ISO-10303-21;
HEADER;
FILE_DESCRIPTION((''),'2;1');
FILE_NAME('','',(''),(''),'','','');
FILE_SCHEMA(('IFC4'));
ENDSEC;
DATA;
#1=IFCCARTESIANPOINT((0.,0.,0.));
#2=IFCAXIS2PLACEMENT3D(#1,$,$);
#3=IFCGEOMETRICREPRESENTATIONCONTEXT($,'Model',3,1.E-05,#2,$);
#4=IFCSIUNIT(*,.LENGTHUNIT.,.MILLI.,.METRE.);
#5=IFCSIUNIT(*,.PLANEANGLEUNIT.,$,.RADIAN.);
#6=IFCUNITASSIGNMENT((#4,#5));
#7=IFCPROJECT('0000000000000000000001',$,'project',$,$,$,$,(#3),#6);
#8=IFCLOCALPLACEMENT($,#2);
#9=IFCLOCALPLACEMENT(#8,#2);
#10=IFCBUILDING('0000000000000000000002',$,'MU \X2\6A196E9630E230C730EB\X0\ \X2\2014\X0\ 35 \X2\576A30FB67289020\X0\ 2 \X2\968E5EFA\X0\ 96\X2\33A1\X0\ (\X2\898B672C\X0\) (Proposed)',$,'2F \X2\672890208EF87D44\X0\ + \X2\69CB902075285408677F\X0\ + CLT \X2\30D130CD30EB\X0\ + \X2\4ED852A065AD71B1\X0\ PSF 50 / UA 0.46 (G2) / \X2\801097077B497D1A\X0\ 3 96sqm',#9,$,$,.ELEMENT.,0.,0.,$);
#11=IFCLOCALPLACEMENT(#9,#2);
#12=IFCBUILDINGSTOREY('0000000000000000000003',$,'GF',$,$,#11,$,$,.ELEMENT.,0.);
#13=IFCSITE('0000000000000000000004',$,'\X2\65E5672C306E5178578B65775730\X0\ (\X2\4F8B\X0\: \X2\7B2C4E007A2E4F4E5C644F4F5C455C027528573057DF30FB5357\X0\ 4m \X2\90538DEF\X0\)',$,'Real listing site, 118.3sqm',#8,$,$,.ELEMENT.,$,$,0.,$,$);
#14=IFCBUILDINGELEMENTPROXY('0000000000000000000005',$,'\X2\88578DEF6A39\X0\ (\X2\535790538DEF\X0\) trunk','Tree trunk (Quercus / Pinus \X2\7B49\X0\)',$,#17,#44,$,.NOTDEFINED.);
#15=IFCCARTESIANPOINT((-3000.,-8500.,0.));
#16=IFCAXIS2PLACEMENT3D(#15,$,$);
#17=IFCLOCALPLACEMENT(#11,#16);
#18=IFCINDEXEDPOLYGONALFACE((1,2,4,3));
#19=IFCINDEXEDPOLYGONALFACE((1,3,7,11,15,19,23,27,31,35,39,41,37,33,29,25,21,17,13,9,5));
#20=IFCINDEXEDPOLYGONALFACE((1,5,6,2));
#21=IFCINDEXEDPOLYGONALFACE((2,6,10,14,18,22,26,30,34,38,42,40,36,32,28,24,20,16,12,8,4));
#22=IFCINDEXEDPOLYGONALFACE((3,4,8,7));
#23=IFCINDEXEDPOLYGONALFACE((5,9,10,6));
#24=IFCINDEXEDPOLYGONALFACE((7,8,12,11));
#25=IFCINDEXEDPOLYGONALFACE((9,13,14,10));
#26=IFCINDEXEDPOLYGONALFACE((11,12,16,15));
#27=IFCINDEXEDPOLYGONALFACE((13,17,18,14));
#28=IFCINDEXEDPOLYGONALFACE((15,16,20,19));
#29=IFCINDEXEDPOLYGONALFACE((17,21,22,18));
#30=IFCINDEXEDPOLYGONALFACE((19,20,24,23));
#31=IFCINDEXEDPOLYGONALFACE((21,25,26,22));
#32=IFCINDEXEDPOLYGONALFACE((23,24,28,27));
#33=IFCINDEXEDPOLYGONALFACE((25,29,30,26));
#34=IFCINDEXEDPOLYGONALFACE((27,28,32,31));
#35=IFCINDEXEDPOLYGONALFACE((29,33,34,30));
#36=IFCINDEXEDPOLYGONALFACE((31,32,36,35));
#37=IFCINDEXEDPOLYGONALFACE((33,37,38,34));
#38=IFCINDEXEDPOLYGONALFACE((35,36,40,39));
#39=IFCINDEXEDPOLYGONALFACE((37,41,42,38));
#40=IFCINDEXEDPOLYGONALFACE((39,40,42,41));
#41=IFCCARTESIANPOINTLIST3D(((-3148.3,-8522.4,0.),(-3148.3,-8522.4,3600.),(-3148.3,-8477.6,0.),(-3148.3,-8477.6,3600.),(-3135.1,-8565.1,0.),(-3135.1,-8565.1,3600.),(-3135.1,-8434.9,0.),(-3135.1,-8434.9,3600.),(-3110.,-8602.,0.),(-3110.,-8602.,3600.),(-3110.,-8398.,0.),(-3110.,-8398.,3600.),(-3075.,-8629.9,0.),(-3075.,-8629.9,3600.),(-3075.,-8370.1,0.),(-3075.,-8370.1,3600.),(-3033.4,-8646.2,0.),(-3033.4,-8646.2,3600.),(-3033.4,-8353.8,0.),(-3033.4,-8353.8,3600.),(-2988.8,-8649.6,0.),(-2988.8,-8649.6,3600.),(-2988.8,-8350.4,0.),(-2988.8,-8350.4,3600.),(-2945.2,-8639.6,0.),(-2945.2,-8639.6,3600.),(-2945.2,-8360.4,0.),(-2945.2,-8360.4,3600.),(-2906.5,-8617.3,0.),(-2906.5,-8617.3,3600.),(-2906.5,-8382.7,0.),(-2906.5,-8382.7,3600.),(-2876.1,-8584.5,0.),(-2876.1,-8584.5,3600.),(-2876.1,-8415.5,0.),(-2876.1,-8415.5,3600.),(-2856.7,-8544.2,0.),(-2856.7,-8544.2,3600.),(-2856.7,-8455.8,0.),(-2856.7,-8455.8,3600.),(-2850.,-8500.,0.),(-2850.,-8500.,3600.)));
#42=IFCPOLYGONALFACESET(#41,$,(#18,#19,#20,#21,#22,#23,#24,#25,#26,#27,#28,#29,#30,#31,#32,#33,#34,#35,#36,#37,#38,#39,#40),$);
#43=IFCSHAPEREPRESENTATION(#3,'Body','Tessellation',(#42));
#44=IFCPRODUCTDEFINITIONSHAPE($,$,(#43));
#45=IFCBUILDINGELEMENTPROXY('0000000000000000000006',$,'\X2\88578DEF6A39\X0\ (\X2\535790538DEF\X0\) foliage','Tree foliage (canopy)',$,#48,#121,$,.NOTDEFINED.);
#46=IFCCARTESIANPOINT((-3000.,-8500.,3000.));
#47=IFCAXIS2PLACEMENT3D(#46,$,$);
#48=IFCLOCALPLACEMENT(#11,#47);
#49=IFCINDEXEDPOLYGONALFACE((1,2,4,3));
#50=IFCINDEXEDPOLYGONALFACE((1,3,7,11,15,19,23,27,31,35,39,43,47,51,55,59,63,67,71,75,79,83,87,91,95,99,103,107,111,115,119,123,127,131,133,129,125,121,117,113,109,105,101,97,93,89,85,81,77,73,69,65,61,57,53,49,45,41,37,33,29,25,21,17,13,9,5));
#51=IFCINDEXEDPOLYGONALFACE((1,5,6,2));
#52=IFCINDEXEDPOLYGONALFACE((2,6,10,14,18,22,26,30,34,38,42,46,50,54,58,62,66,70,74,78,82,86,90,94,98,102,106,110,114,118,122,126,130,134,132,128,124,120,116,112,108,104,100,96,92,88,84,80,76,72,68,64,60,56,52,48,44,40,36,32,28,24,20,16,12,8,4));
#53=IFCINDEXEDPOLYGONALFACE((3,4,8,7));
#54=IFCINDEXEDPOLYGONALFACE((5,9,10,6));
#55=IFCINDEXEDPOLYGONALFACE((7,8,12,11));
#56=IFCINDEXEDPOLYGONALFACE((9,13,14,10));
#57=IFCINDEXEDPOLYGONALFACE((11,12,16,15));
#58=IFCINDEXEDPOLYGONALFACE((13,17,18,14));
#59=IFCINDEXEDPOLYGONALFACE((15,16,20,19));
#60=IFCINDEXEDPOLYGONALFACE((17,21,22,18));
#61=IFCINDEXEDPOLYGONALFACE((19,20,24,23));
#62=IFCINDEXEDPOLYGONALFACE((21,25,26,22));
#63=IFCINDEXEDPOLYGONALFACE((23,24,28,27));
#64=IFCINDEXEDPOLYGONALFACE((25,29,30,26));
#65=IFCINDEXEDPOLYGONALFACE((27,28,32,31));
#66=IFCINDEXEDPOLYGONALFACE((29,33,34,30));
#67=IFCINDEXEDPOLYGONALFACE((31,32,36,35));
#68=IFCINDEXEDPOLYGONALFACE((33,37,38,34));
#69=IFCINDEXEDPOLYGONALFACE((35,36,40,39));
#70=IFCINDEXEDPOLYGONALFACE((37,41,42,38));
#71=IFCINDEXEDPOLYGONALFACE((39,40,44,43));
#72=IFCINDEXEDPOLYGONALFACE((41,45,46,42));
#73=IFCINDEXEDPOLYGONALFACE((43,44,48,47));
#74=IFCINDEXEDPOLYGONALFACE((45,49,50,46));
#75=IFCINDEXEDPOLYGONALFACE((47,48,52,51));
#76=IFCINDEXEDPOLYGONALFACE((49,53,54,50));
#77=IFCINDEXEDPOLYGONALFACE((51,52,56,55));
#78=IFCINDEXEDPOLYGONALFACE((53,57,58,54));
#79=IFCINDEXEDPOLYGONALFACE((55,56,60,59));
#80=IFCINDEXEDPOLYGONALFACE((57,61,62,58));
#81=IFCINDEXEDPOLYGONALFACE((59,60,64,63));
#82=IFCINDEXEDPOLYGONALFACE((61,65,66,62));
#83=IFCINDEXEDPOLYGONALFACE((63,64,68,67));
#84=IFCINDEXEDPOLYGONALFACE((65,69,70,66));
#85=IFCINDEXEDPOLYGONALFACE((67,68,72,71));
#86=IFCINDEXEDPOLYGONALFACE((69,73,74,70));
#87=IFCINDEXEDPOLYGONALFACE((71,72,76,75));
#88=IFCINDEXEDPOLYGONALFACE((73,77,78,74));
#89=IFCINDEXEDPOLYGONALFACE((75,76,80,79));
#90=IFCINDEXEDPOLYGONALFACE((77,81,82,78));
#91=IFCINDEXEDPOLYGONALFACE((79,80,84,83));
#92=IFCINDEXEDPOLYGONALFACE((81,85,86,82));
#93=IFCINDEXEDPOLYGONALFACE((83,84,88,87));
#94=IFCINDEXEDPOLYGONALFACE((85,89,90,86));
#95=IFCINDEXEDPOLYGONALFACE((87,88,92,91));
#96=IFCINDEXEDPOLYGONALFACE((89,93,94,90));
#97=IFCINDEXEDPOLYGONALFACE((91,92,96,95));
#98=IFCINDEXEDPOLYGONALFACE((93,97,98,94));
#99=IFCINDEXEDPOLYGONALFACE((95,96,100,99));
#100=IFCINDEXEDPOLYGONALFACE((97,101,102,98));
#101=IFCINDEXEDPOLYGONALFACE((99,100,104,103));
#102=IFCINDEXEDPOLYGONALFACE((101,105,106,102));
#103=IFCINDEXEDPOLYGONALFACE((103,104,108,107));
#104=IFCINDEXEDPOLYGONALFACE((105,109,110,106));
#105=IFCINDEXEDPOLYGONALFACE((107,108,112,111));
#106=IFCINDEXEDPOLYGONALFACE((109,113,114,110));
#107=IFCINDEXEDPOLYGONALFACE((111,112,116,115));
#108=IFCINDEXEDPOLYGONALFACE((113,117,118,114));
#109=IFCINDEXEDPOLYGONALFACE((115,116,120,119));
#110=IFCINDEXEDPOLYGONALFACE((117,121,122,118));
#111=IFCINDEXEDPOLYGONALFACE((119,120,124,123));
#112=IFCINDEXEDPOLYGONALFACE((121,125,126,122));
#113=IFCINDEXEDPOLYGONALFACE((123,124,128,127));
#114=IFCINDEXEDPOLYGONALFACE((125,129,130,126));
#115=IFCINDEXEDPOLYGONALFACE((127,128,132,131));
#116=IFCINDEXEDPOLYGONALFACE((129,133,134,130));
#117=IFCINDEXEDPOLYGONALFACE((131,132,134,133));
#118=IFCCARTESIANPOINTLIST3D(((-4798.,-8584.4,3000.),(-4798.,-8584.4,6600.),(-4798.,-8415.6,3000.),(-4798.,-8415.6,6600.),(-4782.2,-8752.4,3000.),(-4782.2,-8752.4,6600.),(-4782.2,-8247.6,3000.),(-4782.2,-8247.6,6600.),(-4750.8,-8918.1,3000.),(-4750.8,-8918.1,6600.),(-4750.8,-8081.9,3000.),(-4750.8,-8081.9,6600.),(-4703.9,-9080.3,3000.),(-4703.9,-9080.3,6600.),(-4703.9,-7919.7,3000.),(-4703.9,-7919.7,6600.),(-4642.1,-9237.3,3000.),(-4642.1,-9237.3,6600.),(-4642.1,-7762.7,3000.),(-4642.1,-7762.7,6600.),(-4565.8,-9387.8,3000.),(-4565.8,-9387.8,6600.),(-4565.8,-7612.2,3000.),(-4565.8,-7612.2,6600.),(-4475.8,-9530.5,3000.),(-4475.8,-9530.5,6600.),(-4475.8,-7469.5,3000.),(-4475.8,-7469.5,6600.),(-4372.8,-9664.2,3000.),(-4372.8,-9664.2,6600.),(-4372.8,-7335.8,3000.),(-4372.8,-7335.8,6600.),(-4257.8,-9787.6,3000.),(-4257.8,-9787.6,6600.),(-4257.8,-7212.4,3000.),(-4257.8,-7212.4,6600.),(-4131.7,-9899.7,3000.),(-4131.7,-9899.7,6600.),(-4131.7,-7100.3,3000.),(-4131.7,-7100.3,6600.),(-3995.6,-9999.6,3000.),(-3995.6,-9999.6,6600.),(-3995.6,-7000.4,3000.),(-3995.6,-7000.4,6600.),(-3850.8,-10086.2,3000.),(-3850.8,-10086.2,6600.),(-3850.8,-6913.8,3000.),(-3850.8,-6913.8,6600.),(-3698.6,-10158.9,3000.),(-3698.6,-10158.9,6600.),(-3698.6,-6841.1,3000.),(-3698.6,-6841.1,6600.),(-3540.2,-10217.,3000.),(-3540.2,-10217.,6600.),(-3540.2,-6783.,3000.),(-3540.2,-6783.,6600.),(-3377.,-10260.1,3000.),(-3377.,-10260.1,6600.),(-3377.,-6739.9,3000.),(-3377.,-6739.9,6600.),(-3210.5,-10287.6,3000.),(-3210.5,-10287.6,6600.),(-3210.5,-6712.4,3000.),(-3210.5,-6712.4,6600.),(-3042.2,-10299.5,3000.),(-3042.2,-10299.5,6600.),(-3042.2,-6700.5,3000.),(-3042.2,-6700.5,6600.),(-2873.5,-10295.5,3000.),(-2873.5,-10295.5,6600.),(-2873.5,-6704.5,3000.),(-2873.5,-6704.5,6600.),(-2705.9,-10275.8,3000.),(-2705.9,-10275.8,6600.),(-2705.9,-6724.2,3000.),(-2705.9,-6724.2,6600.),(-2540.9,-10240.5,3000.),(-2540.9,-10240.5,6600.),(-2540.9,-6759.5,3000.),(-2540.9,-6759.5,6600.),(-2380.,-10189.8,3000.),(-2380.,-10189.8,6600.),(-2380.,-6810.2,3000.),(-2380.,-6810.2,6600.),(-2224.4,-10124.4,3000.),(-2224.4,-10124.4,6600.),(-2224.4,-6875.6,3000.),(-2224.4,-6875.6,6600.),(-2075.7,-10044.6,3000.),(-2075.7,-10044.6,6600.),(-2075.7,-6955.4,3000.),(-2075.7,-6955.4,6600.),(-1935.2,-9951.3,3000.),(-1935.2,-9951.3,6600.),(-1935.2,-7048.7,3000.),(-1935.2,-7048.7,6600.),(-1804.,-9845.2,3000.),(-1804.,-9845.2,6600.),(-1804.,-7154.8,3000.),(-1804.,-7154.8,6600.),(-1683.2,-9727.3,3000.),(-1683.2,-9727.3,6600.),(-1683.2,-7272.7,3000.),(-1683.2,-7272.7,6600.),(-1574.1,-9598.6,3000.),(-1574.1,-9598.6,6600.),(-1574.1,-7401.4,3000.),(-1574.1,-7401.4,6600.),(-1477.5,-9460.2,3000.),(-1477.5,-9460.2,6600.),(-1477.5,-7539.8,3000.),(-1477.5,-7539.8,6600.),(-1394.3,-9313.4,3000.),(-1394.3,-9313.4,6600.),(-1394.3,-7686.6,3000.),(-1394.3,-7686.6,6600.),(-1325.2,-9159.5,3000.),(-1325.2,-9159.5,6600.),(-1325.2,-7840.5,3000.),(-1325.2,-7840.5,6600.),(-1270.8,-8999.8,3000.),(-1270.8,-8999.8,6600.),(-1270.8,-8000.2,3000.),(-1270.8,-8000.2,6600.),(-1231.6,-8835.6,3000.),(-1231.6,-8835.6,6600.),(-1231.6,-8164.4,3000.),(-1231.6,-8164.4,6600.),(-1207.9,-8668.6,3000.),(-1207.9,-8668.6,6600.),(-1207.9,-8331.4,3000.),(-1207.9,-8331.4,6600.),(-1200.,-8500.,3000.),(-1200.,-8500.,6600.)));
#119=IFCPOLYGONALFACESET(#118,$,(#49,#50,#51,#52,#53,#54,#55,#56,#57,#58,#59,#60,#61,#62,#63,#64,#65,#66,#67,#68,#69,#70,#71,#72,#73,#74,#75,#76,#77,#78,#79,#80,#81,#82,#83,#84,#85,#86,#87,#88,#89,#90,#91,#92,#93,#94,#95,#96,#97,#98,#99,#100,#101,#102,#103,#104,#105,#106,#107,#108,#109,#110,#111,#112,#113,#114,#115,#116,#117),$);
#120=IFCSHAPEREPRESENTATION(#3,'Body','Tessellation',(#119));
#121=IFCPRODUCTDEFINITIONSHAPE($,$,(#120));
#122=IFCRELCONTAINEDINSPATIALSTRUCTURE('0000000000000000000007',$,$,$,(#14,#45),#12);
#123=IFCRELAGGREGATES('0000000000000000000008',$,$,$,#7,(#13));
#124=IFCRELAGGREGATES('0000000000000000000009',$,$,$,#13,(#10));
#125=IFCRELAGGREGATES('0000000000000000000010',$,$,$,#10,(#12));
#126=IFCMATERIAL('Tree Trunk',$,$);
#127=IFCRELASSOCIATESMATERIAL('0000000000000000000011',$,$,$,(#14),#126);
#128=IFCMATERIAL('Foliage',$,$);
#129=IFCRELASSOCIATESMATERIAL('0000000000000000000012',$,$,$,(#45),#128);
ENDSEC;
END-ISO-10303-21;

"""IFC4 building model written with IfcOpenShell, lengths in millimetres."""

from ifc_helpers import new_model, si_unit, frame, origin, origin_2d, place, context, project, spatial, circle, extrude, material, element, save


model = new_model("IFC4")

# Units and contexts
model_context = context("Model", 3, precision=1e-05, world=origin())
ifc_project = project(units=[si_unit("LENGTHUNIT", "METRE", prefix="MILLI"), si_unit("PLANEANGLEUNIT", "RADIAN")], contexts=[model_context])

# Site, building, storey
site_placement = place(None, origin())
site = spatial("IfcSite", under=ifc_project, at=site_placement, Name="日本の典型敷地 (例: 第一種低層住居専用地域・南 4m 道路)", ObjectType="Real listing site, 118.3sqm", CompositionType="ELEMENT", RefElevation=0.0)
building_placement = place(site_placement, origin())
building = spatial("IfcBuilding", under=site, at=building_placement, Name="MU 標準モデル — 35 坪・木造 2 階建 96㎡ (見本) (Proposed)", ObjectType="2F 木造軸組 + 構造用合板 + CLT パネル + 付加断熱 PSF 50 / UA 0.46 (G2) / 耐震等級 3 96sqm", CompositionType="ELEMENT", ElevationOfRefHeight=0.0, ElevationOfTerrain=0.0)
storey_placement = place(building_placement, origin())
storey = spatial("IfcBuildingStorey", under=building, at=storey_placement, Name="GF", CompositionType="ELEMENT", Elevation=0.0)

# Building element proxies
ifc_material_1 = material(Name="Tree Trunk")
ifc_material_2 = material(Name="Foliage")
proxy_1_placement = place(storey_placement, frame((-3000.0, -8500.0, 0.0)))
element("IfcBuildingElementProxy", 1, at=proxy_1_placement, inside=storey, material=ifc_material_1, Name="街路樹 (南道路) trunk", Description="Tree trunk (Quercus / Pinus 等)", PredefinedType="NOTDEFINED", context=model_context, shape_type="SweptSolid", body=[
    extrude(circle(Radius=150.0, at=origin_2d()), frame((-3000.0, -8500.0, 0.0)), (0.0, 0.0, 1.0), 3600.0),
])
proxy_2_placement = place(storey_placement, frame((-3000.0, -8500.0, 3000.0)))
element("IfcBuildingElementProxy", 2, at=proxy_2_placement, inside=storey, material=ifc_material_2, Name="街路樹 (南道路) foliage", Description="Tree foliage (canopy)", PredefinedType="NOTDEFINED", context=model_context, shape_type="SweptSolid", body=[
    extrude(circle(Radius=1800.0, at=origin_2d()), frame((-3000.0, -8500.0, 3000.0)), (0.0, 0.0, 1.0), 3600.0),
])

save(model, "model.ifc")
